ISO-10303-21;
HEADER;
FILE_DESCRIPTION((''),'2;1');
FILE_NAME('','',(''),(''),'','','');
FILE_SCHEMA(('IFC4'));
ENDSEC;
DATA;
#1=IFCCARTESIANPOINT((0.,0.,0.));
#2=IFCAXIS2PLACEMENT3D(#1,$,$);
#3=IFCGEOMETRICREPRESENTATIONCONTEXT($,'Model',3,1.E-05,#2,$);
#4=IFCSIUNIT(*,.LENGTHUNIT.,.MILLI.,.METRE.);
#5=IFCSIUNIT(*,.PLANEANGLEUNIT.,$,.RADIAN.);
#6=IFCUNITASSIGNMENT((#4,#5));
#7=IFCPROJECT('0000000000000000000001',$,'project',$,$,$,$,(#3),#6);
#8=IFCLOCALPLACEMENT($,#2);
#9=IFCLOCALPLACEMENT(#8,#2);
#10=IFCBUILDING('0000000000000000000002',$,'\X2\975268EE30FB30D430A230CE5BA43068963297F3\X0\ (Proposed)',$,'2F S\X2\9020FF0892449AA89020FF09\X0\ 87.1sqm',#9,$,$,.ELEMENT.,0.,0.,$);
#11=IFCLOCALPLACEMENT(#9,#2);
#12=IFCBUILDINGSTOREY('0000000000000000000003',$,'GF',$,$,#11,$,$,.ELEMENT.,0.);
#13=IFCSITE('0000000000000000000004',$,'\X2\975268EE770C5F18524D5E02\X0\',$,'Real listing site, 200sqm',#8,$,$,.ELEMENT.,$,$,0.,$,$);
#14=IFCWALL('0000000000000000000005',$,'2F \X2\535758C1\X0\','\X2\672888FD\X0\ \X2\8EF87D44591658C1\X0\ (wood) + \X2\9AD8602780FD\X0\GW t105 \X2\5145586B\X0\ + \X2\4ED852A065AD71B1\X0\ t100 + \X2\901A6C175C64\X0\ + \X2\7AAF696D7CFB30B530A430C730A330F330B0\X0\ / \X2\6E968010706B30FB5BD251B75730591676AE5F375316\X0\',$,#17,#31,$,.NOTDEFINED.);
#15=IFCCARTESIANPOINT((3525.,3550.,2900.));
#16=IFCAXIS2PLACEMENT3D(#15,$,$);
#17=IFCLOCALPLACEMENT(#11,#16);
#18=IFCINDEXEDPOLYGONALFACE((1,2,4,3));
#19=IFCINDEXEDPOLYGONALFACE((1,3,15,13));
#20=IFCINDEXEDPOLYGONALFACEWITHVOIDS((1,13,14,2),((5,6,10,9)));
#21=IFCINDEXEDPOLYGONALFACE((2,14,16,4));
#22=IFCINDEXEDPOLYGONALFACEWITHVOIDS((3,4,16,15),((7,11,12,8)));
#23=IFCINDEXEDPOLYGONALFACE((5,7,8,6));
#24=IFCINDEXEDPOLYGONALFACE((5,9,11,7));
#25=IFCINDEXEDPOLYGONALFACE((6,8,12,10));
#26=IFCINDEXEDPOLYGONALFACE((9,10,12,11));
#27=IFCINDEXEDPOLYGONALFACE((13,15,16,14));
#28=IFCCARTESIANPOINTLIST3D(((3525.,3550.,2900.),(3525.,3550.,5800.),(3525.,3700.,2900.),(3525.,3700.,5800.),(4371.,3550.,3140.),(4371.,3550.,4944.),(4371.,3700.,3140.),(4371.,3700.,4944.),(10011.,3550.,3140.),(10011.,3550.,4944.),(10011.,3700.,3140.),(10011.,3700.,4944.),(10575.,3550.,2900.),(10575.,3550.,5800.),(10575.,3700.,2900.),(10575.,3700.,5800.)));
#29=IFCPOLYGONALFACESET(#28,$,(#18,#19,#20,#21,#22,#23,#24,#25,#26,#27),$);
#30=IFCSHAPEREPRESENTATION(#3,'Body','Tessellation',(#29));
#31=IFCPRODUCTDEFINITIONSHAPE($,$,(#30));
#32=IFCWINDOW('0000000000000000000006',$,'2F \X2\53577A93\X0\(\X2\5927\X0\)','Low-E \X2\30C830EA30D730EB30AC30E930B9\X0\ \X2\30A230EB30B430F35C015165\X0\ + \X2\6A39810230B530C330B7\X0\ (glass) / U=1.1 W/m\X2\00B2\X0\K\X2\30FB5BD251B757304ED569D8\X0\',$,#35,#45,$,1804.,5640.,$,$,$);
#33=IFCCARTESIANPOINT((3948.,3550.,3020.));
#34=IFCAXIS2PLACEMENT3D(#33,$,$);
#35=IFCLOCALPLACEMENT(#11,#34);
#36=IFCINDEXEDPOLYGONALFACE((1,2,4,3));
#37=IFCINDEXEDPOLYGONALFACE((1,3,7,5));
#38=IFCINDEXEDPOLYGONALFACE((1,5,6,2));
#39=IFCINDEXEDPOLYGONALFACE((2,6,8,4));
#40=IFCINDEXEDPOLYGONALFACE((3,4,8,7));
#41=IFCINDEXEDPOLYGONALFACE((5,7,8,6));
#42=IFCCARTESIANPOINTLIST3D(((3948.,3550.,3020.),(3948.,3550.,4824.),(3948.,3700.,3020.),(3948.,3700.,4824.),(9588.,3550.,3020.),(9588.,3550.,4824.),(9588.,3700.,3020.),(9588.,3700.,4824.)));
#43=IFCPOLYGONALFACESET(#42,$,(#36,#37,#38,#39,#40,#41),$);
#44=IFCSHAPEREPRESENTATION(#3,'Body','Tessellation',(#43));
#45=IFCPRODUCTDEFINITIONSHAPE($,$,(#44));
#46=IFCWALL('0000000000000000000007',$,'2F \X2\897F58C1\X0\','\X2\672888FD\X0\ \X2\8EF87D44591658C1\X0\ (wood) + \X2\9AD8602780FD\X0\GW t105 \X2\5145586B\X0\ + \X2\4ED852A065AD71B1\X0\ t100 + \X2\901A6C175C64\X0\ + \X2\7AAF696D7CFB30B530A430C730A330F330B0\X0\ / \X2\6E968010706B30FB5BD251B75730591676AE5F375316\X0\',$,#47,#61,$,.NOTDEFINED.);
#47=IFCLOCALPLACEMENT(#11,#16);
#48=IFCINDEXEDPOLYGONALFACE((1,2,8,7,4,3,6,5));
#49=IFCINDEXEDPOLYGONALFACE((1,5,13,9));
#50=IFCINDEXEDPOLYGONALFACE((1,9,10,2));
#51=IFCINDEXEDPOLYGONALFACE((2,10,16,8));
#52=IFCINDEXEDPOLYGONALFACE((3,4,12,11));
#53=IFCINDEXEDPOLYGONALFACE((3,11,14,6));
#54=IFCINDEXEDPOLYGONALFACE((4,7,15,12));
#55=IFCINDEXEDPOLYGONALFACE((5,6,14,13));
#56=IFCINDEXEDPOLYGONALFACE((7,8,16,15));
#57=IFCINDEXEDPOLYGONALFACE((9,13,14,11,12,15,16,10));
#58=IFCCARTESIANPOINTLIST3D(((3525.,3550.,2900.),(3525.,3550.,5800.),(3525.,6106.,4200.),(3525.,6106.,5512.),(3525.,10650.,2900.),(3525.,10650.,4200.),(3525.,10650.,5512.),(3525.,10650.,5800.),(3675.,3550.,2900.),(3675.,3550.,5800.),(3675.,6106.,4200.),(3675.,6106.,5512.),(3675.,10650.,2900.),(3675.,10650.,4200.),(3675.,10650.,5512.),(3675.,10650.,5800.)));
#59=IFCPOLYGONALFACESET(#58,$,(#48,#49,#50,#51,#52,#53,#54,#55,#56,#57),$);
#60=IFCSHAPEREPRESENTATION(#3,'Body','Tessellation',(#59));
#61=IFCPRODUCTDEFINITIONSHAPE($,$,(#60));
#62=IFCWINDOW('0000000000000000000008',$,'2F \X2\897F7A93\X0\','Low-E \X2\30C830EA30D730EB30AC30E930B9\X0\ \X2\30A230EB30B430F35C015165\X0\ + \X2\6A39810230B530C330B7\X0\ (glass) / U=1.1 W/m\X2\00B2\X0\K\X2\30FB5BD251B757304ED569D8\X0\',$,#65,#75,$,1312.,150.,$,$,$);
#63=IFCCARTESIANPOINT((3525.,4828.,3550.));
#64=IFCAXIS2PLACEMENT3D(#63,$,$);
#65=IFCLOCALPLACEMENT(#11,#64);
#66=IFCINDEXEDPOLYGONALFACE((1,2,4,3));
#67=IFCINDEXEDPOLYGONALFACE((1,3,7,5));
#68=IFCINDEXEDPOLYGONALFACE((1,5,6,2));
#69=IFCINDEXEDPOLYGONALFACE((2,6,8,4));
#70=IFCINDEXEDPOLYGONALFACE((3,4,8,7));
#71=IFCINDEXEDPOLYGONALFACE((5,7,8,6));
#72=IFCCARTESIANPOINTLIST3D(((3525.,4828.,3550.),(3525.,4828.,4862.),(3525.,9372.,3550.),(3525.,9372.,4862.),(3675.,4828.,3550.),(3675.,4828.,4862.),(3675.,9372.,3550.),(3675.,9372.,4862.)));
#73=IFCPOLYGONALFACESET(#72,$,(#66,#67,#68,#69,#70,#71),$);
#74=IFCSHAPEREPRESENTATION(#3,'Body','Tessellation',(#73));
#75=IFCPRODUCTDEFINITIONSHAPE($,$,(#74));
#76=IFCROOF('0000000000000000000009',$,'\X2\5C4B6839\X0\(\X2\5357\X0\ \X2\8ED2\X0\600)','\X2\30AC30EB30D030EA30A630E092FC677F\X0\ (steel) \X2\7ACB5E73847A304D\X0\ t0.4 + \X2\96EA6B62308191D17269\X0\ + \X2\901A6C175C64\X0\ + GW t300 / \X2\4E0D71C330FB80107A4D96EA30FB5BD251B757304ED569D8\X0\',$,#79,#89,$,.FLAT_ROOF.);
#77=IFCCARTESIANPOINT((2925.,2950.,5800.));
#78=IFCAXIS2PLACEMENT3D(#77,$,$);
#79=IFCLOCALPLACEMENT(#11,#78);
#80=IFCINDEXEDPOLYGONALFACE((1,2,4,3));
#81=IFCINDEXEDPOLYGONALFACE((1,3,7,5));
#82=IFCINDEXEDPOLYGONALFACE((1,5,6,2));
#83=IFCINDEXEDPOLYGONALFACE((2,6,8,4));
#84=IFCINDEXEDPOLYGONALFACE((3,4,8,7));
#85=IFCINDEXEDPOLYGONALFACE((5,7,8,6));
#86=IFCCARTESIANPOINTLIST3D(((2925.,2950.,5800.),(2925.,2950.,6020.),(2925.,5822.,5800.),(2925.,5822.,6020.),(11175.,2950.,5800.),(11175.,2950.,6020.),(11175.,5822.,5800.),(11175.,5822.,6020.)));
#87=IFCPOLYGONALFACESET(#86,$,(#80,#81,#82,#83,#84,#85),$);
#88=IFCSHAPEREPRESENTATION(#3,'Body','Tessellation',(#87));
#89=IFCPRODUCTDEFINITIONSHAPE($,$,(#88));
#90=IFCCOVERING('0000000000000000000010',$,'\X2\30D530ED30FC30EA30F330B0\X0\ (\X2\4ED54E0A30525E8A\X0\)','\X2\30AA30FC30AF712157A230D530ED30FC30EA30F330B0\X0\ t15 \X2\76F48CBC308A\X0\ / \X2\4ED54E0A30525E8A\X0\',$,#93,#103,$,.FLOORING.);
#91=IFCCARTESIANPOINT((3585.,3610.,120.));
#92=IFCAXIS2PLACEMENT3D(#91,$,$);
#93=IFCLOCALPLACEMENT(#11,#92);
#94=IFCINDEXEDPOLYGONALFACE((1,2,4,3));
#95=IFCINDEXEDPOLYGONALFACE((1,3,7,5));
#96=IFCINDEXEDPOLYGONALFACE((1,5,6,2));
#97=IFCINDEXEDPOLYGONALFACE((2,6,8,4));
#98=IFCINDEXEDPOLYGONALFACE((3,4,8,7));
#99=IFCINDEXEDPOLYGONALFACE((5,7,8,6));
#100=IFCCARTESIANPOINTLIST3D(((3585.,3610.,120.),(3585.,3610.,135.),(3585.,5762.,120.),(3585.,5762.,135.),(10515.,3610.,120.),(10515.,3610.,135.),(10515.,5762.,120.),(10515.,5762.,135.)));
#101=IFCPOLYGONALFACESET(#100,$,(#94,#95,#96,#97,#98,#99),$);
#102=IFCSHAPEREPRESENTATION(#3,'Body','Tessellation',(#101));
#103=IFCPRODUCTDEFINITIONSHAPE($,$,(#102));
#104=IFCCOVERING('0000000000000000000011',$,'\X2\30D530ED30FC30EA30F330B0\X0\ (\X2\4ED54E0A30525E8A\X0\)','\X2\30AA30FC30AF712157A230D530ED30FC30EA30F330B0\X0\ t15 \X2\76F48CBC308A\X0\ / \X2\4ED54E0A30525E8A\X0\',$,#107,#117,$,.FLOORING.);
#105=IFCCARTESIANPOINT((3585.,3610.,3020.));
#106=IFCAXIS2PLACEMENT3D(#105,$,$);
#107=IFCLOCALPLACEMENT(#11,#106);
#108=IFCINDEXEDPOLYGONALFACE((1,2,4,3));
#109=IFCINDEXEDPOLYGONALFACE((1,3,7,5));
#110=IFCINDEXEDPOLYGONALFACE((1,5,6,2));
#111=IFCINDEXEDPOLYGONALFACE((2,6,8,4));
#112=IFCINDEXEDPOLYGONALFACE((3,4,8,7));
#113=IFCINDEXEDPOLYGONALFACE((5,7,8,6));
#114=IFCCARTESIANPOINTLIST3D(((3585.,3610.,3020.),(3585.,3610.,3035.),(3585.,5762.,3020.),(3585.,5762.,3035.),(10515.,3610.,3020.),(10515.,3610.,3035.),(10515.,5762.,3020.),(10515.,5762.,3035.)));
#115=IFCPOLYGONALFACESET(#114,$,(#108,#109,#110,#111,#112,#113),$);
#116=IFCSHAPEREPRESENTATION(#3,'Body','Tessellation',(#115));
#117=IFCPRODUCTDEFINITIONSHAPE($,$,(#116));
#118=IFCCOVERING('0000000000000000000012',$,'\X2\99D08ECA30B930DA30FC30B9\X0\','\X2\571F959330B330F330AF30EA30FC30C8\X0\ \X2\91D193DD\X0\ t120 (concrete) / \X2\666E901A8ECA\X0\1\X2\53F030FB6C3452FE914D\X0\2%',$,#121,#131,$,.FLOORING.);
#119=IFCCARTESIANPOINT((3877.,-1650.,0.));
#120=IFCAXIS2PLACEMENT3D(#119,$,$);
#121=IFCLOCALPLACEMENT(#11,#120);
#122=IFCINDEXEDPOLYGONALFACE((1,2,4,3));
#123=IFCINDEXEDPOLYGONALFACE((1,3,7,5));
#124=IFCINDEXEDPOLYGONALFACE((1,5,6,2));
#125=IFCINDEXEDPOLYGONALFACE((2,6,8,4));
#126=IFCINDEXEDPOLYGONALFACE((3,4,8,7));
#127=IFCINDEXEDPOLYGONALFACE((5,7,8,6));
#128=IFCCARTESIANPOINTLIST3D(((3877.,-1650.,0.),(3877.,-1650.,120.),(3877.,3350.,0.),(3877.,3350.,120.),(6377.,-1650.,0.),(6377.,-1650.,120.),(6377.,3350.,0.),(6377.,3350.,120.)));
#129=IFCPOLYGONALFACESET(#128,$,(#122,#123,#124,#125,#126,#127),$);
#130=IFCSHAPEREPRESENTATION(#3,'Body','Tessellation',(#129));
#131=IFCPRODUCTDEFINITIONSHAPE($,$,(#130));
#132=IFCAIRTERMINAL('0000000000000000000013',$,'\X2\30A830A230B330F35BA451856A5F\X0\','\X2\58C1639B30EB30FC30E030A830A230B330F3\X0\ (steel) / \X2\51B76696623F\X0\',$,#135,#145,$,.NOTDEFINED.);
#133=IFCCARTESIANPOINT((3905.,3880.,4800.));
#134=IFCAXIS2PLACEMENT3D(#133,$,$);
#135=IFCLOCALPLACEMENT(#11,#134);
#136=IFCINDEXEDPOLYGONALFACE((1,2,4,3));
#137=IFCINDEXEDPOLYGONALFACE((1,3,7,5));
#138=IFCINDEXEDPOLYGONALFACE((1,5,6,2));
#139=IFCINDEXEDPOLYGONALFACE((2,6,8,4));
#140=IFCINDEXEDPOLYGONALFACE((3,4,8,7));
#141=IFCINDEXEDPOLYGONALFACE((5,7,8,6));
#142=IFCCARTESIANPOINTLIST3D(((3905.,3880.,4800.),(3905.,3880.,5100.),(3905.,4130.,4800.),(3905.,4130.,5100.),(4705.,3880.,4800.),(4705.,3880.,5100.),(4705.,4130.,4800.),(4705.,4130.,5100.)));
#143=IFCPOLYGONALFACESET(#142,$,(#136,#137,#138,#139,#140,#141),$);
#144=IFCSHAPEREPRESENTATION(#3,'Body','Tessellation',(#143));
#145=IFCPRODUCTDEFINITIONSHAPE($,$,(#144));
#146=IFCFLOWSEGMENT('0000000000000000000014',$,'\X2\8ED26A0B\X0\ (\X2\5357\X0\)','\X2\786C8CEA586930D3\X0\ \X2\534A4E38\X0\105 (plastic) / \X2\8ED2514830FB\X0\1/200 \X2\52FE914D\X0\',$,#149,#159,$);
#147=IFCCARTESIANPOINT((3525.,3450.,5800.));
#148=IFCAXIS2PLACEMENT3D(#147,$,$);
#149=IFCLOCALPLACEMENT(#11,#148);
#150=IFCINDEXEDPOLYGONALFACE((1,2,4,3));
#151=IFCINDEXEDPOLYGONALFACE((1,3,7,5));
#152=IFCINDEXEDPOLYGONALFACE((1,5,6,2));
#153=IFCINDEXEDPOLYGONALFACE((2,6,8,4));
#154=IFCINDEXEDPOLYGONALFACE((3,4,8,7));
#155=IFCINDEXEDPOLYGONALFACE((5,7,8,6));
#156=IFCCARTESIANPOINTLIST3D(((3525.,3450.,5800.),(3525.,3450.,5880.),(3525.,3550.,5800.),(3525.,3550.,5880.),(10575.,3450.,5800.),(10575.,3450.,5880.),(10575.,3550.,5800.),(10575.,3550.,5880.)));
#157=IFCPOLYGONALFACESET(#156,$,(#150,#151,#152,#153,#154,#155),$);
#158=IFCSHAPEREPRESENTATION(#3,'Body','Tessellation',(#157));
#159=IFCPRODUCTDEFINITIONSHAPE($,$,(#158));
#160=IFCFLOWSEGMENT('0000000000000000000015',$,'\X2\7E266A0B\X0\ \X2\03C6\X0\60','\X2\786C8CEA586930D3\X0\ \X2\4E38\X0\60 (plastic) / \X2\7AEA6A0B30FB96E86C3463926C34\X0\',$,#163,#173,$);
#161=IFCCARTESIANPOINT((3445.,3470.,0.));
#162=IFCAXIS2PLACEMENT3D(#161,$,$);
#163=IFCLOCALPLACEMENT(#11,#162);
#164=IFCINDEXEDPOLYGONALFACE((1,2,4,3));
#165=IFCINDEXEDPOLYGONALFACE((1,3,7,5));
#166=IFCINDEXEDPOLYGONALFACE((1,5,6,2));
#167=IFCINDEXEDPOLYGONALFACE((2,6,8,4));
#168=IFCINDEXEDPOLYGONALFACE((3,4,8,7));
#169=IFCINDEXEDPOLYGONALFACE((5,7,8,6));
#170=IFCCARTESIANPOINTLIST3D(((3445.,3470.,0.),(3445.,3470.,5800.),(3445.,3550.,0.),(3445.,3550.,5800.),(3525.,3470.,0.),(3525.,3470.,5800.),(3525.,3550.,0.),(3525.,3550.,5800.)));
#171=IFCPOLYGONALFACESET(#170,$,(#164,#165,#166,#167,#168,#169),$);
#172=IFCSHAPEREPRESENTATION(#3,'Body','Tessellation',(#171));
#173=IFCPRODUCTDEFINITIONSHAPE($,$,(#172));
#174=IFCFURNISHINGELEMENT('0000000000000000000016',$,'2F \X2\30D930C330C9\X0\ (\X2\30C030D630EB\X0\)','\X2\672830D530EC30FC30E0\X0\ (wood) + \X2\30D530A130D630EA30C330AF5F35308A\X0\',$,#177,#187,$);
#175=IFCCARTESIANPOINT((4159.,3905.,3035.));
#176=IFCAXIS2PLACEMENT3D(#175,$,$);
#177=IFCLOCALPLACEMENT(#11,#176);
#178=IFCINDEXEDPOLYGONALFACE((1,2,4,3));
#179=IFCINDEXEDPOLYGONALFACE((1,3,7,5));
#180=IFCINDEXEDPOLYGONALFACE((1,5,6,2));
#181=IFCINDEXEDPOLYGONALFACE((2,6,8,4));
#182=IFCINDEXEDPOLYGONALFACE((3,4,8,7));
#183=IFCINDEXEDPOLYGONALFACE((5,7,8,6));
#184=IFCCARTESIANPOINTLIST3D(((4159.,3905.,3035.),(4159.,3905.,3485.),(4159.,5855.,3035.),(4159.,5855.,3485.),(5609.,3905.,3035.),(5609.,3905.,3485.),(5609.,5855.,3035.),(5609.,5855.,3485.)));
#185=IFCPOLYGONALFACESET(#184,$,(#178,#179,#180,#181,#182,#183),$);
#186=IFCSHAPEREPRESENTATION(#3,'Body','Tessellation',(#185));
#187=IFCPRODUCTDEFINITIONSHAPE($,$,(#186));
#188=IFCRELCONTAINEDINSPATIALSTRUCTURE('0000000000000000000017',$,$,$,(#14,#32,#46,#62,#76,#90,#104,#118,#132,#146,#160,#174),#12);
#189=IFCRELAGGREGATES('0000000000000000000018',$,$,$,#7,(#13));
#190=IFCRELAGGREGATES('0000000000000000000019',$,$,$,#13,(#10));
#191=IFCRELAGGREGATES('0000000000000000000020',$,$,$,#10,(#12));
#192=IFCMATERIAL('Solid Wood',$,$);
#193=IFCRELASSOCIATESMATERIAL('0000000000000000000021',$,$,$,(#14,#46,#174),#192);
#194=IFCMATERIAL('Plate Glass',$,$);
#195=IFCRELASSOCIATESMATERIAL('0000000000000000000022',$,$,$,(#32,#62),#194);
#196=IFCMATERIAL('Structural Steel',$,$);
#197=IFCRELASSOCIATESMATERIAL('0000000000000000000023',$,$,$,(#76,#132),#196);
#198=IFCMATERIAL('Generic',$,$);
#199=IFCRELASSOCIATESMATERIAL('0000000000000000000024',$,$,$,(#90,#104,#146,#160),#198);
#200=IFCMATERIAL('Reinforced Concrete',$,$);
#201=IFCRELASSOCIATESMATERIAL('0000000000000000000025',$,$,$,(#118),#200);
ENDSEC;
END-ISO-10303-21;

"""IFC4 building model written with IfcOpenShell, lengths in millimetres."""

from ifc_helpers import new_model, si_unit, frame, frame_2d, origin, place, context, project, spatial, rectangle, extrude, material, element, fill, save


model = new_model("IFC4")

# Units and contexts
model_context = context("Model", 3, precision=1e-05, world=origin())
ifc_project = project(units=[si_unit("LENGTHUNIT", "METRE", prefix="MILLI"), si_unit("PLANEANGLEUNIT", "RADIAN")], contexts=[model_context])

# Site, building, storey
site_placement = place(None, origin())
site = spatial("IfcSite", under=ifc_project, at=site_placement, Name="青森県弘前市", ObjectType="Real listing site, 200sqm", CompositionType="ELEMENT", RefElevation=0.0)
building_placement = place(site_placement, origin())
building = spatial("IfcBuilding", under=site, at=building_placement, Name="青森・ピアノ室と防音 (Proposed)", ObjectType="2F S造（鉄骨造） 87.1sqm", CompositionType="ELEMENT", ElevationOfRefHeight=0.0, ElevationOfTerrain=0.0)
storey_placement = place(building_placement, origin())
storey = spatial("IfcBuildingStorey", under=building, at=storey_placement, Name="GF", CompositionType="ELEMENT", Elevation=0.0)

# Shared definitions
ifc_material_1 = material(Name="Solid Wood")

# Shared definitions
ifc_material_2 = material(Name="Reinforced Concrete")

# Shared definitions
ifc_material_3 = material(Name="Plate Glass")

# Walls, openings, windows
wall_1_placement = place(storey_placement, frame((3525.0, 3550.0, 2900.0)))
wall_1 = element("IfcWall", 1, at=wall_1_placement, inside=storey, material=ifc_material_1, Name="2F 南壁", Description="木製 軸組外壁 (wood) + 高性能GW t105 充填 + 付加断熱 t100 + 通気層 + 窯業系サイディング / 準耐火・寒冷地外皮強化", PredefinedType="NOTDEFINED", context=model_context, shape_type="SweptSolid", body=[
    extrude(rectangle(XDim=7050.0, YDim=150.0, at=frame_2d((3525.0, 75.0))), frame((3525.0, 3550.0, 2900.0)), (0.0, 0.0, 1.0), 2900.0),
])
opening_1_placement = place(storey_placement, frame((3948.0, 3550.0, 3020.0)))
opening_1 = element("IfcOpeningElement", 2, at=opening_1_placement, cuts=wall_1, PredefinedType="NOTDEFINED", context=model_context, shape_type="SweptSolid", body=[
    extrude(rectangle(XDim=5640.0, YDim=150.0, at=frame_2d((2820.0, 75.0))), frame((3948.0, 3550.0, 3020.0)), (0.0, 0.0, 1.0), 1804.0),
])
window_1_placement = place(storey_placement, frame((3948.0, 3550.0, 3020.0)))
window_1 = element("IfcWindow", 3, at=window_1_placement, inside=storey, material=ifc_material_3, Name="2F 南窓(大)", Description="Low-E トリプルガラス アルゴン封入 + 樹脂サッシ (glass) / U=1.1 W/m²K・寒冷地仕様", OverallHeight=1804.0, OverallWidth=5640.0, context=model_context, shape_type="SweptSolid", body=[
    extrude(rectangle(XDim=5640.0, YDim=150.0, at=frame_2d((2820.0, 75.0))), frame((3948.0, 3550.0, 3020.0)), (0.0, 0.0, 1.0), 1804.0),
])
fill(opening_1, window_1)
wall_2_placement = place(storey_placement, frame((3525.0, 3550.0, 2900.0)))
wall_2 = element("IfcWall", 4, at=wall_2_placement, inside=storey, material=ifc_material_1, Name="2F 西壁", Description="木製 軸組外壁 (wood) + 高性能GW t105 充填 + 付加断熱 t100 + 通気層 + 窯業系サイディング / 準耐火・寒冷地外皮強化", PredefinedType="NOTDEFINED", context=model_context, shape_type="SweptSolid", body=[
    extrude(rectangle(XDim=150.0, YDim=7100.0, at=frame_2d((75.0, 3550.0))), frame((3525.0, 3550.0, 2900.0)), (0.0, 0.0, 1.0), 2900.0),
])
opening_2_placement = place(storey_placement, frame((3525.0, 4828.0, 3550.0)))
opening_2 = element("IfcOpeningElement", 5, at=opening_2_placement, cuts=wall_2, PredefinedType="NOTDEFINED", context=model_context, shape_type="SweptSolid", body=[
    extrude(rectangle(XDim=150.0, YDim=4544.0, at=frame_2d((75.0, 2272.0))), frame((3525.0, 4828.0, 3550.0)), (0.0, 0.0, 1.0), 1312.0),
])
window_2_placement = place(storey_placement, frame((3525.0, 4828.0, 3550.0)))
window_2 = element("IfcWindow", 6, at=window_2_placement, inside=storey, material=ifc_material_3, Name="2F 西窓", Description="Low-E トリプルガラス アルゴン封入 + 樹脂サッシ (glass) / U=1.1 W/m²K・寒冷地仕様", OverallHeight=1312.0, OverallWidth=150.0, context=model_context, shape_type="SweptSolid", body=[
    extrude(rectangle(XDim=150.0, YDim=4544.0, at=frame_2d((75.0, 2272.0))), frame((3525.0, 4828.0, 3550.0)), (0.0, 0.0, 1.0), 1312.0),
])
fill(opening_2, window_2)

# Roof
ifc_material_4 = material(Name="Structural Steel")
for number, where, name in (
    (7, (2925.0, 2950.0, 5800.0), "屋根(南 軒600)"),
):
    element("IfcRoof", number, at=place(storey_placement, frame(where)), inside=storey, material=ifc_material_4, Name=name, Description="ガルバリウム鋼板 (steel) 立平葺き t0.4 + 雪止め金物 + 通気層 + GW t300 / 不燃・耐積雪・寒冷地仕様", PredefinedType="FLAT_ROOF", context=model_context, shape_type="SweptSolid", body=[
        extrude(rectangle(XDim=8250.0, YDim=2872.0, at=frame_2d((4125.0, 1436.0))), frame((2925.0, 2950.0, 5800.0)), (0.0, 0.0, 1.0), 220.0),
    ])

# Coverings
ifc_material_5 = material(Name="Generic")
covering_1_placement = place(storey_placement, frame((3585.0, 3610.0, 120.0)))
element("IfcCovering", 8, at=covering_1_placement, inside=storey, material=ifc_material_5, Name="フローリング (仕上げ床)", Description="オーク無垢フローリング t15 直貼り / 仕上げ床", PredefinedType="FLOORING", context=model_context, shape_type="SweptSolid", body=[
    extrude(rectangle(XDim=6930.0, YDim=2152.0, at=frame_2d((3465.0, 1076.0))), frame((3585.0, 3610.0, 120.0)), (0.0, 0.0, 1.0), 15.0),
])
covering_2_placement = place(storey_placement, frame((3585.0, 3610.0, 3020.0)))
element("IfcCovering", 9, at=covering_2_placement, inside=storey, material=ifc_material_5, Name="フローリング (仕上げ床)", Description="オーク無垢フローリング t15 直貼り / 仕上げ床", PredefinedType="FLOORING", context=model_context, shape_type="SweptSolid", body=[
    extrude(rectangle(XDim=6930.0, YDim=2152.0, at=frame_2d((3465.0, 1076.0))), frame((3585.0, 3610.0, 3020.0)), (0.0, 0.0, 1.0), 15.0),
])
covering_3_placement = place(storey_placement, frame((3877.0, -1650.0, 0.0)))
element("IfcCovering", 10, at=covering_3_placement, inside=storey, material=ifc_material_2, Name="駐車スペース", Description="土間コンクリート 金鏝 t120 (concrete) / 普通車1台・水勾配2%", PredefinedType="FLOORING", context=model_context, shape_type="SweptSolid", body=[
    extrude(rectangle(XDim=2500.0, YDim=5000.0, at=frame_2d((1250.0, 2500.0))), frame((3877.0, -1650.0, 0.0)), (0.0, 0.0, 1.0), 120.0),
])

# Air terminal
air_terminal_placement = place(storey_placement, frame((3905.0, 3880.0, 4800.0)))
element("IfcAirTerminal", 11, at=air_terminal_placement, inside=storey, material=ifc_material_4, Name="エアコン室内機", Description="壁掛ルームエアコン (steel) / 冷暖房", PredefinedType="NOTDEFINED", context=model_context, shape_type="SweptSolid", body=[
    extrude(rectangle(XDim=800.0, YDim=250.0, at=frame_2d((400.0, 125.0))), frame((3905.0, 3880.0, 4800.0)), (0.0, 0.0, 1.0), 300.0),
])

# Flow segments
flow_segment_1_placement = place(storey_placement, frame((3525.0, 3450.0, 5800.0)))
element("IfcFlowSegment", 12, at=flow_segment_1_placement, inside=storey, material=ifc_material_5, Name="軒樋 (南)", Description="硬質塩ビ 半丸105 (plastic) / 軒先・1/200 勾配", context=model_context, shape_type="SweptSolid", body=[
    extrude(rectangle(XDim=7050.0, YDim=100.0, at=frame_2d((3525.0, 50.0))), frame((3525.0, 3450.0, 5800.0)), (0.0, 0.0, 1.0), 80.0),
])
flow_segment_2_placement = place(storey_placement, frame((3445.0, 3470.0, 0.0)))
element("IfcFlowSegment", 13, at=flow_segment_2_placement, inside=storey, material=ifc_material_5, Name="縦樋 φ60", Description="硬質塩ビ 丸60 (plastic) / 竪樋・雨水排水", context=model_context, shape_type="SweptSolid", body=[
    extrude(rectangle(XDim=80.0, YDim=80.0, at=frame_2d((40.0, 40.0))), frame((3445.0, 3470.0, 0.0)), (0.0, 0.0, 1.0), 5800.0),
])

# Furnishing element
furnishing_placement = place(storey_placement, frame((4159.0, 3905.0, 3035.0)))
element("IfcFurnishingElement", 14, at=furnishing_placement, inside=storey, material=ifc_material_1, Name="2F ベッド (ダブル)", Description="木フレーム (wood) + ファブリック張り", context=model_context, shape_type="SweptSolid", body=[
    extrude(rectangle(XDim=1450.0, YDim=1950.0, at=frame_2d((725.0, 975.0))), frame((4159.0, 3905.0, 3035.0)), (0.0, 0.0, 1.0), 450.0),
])

save(model, "model.ifc")
